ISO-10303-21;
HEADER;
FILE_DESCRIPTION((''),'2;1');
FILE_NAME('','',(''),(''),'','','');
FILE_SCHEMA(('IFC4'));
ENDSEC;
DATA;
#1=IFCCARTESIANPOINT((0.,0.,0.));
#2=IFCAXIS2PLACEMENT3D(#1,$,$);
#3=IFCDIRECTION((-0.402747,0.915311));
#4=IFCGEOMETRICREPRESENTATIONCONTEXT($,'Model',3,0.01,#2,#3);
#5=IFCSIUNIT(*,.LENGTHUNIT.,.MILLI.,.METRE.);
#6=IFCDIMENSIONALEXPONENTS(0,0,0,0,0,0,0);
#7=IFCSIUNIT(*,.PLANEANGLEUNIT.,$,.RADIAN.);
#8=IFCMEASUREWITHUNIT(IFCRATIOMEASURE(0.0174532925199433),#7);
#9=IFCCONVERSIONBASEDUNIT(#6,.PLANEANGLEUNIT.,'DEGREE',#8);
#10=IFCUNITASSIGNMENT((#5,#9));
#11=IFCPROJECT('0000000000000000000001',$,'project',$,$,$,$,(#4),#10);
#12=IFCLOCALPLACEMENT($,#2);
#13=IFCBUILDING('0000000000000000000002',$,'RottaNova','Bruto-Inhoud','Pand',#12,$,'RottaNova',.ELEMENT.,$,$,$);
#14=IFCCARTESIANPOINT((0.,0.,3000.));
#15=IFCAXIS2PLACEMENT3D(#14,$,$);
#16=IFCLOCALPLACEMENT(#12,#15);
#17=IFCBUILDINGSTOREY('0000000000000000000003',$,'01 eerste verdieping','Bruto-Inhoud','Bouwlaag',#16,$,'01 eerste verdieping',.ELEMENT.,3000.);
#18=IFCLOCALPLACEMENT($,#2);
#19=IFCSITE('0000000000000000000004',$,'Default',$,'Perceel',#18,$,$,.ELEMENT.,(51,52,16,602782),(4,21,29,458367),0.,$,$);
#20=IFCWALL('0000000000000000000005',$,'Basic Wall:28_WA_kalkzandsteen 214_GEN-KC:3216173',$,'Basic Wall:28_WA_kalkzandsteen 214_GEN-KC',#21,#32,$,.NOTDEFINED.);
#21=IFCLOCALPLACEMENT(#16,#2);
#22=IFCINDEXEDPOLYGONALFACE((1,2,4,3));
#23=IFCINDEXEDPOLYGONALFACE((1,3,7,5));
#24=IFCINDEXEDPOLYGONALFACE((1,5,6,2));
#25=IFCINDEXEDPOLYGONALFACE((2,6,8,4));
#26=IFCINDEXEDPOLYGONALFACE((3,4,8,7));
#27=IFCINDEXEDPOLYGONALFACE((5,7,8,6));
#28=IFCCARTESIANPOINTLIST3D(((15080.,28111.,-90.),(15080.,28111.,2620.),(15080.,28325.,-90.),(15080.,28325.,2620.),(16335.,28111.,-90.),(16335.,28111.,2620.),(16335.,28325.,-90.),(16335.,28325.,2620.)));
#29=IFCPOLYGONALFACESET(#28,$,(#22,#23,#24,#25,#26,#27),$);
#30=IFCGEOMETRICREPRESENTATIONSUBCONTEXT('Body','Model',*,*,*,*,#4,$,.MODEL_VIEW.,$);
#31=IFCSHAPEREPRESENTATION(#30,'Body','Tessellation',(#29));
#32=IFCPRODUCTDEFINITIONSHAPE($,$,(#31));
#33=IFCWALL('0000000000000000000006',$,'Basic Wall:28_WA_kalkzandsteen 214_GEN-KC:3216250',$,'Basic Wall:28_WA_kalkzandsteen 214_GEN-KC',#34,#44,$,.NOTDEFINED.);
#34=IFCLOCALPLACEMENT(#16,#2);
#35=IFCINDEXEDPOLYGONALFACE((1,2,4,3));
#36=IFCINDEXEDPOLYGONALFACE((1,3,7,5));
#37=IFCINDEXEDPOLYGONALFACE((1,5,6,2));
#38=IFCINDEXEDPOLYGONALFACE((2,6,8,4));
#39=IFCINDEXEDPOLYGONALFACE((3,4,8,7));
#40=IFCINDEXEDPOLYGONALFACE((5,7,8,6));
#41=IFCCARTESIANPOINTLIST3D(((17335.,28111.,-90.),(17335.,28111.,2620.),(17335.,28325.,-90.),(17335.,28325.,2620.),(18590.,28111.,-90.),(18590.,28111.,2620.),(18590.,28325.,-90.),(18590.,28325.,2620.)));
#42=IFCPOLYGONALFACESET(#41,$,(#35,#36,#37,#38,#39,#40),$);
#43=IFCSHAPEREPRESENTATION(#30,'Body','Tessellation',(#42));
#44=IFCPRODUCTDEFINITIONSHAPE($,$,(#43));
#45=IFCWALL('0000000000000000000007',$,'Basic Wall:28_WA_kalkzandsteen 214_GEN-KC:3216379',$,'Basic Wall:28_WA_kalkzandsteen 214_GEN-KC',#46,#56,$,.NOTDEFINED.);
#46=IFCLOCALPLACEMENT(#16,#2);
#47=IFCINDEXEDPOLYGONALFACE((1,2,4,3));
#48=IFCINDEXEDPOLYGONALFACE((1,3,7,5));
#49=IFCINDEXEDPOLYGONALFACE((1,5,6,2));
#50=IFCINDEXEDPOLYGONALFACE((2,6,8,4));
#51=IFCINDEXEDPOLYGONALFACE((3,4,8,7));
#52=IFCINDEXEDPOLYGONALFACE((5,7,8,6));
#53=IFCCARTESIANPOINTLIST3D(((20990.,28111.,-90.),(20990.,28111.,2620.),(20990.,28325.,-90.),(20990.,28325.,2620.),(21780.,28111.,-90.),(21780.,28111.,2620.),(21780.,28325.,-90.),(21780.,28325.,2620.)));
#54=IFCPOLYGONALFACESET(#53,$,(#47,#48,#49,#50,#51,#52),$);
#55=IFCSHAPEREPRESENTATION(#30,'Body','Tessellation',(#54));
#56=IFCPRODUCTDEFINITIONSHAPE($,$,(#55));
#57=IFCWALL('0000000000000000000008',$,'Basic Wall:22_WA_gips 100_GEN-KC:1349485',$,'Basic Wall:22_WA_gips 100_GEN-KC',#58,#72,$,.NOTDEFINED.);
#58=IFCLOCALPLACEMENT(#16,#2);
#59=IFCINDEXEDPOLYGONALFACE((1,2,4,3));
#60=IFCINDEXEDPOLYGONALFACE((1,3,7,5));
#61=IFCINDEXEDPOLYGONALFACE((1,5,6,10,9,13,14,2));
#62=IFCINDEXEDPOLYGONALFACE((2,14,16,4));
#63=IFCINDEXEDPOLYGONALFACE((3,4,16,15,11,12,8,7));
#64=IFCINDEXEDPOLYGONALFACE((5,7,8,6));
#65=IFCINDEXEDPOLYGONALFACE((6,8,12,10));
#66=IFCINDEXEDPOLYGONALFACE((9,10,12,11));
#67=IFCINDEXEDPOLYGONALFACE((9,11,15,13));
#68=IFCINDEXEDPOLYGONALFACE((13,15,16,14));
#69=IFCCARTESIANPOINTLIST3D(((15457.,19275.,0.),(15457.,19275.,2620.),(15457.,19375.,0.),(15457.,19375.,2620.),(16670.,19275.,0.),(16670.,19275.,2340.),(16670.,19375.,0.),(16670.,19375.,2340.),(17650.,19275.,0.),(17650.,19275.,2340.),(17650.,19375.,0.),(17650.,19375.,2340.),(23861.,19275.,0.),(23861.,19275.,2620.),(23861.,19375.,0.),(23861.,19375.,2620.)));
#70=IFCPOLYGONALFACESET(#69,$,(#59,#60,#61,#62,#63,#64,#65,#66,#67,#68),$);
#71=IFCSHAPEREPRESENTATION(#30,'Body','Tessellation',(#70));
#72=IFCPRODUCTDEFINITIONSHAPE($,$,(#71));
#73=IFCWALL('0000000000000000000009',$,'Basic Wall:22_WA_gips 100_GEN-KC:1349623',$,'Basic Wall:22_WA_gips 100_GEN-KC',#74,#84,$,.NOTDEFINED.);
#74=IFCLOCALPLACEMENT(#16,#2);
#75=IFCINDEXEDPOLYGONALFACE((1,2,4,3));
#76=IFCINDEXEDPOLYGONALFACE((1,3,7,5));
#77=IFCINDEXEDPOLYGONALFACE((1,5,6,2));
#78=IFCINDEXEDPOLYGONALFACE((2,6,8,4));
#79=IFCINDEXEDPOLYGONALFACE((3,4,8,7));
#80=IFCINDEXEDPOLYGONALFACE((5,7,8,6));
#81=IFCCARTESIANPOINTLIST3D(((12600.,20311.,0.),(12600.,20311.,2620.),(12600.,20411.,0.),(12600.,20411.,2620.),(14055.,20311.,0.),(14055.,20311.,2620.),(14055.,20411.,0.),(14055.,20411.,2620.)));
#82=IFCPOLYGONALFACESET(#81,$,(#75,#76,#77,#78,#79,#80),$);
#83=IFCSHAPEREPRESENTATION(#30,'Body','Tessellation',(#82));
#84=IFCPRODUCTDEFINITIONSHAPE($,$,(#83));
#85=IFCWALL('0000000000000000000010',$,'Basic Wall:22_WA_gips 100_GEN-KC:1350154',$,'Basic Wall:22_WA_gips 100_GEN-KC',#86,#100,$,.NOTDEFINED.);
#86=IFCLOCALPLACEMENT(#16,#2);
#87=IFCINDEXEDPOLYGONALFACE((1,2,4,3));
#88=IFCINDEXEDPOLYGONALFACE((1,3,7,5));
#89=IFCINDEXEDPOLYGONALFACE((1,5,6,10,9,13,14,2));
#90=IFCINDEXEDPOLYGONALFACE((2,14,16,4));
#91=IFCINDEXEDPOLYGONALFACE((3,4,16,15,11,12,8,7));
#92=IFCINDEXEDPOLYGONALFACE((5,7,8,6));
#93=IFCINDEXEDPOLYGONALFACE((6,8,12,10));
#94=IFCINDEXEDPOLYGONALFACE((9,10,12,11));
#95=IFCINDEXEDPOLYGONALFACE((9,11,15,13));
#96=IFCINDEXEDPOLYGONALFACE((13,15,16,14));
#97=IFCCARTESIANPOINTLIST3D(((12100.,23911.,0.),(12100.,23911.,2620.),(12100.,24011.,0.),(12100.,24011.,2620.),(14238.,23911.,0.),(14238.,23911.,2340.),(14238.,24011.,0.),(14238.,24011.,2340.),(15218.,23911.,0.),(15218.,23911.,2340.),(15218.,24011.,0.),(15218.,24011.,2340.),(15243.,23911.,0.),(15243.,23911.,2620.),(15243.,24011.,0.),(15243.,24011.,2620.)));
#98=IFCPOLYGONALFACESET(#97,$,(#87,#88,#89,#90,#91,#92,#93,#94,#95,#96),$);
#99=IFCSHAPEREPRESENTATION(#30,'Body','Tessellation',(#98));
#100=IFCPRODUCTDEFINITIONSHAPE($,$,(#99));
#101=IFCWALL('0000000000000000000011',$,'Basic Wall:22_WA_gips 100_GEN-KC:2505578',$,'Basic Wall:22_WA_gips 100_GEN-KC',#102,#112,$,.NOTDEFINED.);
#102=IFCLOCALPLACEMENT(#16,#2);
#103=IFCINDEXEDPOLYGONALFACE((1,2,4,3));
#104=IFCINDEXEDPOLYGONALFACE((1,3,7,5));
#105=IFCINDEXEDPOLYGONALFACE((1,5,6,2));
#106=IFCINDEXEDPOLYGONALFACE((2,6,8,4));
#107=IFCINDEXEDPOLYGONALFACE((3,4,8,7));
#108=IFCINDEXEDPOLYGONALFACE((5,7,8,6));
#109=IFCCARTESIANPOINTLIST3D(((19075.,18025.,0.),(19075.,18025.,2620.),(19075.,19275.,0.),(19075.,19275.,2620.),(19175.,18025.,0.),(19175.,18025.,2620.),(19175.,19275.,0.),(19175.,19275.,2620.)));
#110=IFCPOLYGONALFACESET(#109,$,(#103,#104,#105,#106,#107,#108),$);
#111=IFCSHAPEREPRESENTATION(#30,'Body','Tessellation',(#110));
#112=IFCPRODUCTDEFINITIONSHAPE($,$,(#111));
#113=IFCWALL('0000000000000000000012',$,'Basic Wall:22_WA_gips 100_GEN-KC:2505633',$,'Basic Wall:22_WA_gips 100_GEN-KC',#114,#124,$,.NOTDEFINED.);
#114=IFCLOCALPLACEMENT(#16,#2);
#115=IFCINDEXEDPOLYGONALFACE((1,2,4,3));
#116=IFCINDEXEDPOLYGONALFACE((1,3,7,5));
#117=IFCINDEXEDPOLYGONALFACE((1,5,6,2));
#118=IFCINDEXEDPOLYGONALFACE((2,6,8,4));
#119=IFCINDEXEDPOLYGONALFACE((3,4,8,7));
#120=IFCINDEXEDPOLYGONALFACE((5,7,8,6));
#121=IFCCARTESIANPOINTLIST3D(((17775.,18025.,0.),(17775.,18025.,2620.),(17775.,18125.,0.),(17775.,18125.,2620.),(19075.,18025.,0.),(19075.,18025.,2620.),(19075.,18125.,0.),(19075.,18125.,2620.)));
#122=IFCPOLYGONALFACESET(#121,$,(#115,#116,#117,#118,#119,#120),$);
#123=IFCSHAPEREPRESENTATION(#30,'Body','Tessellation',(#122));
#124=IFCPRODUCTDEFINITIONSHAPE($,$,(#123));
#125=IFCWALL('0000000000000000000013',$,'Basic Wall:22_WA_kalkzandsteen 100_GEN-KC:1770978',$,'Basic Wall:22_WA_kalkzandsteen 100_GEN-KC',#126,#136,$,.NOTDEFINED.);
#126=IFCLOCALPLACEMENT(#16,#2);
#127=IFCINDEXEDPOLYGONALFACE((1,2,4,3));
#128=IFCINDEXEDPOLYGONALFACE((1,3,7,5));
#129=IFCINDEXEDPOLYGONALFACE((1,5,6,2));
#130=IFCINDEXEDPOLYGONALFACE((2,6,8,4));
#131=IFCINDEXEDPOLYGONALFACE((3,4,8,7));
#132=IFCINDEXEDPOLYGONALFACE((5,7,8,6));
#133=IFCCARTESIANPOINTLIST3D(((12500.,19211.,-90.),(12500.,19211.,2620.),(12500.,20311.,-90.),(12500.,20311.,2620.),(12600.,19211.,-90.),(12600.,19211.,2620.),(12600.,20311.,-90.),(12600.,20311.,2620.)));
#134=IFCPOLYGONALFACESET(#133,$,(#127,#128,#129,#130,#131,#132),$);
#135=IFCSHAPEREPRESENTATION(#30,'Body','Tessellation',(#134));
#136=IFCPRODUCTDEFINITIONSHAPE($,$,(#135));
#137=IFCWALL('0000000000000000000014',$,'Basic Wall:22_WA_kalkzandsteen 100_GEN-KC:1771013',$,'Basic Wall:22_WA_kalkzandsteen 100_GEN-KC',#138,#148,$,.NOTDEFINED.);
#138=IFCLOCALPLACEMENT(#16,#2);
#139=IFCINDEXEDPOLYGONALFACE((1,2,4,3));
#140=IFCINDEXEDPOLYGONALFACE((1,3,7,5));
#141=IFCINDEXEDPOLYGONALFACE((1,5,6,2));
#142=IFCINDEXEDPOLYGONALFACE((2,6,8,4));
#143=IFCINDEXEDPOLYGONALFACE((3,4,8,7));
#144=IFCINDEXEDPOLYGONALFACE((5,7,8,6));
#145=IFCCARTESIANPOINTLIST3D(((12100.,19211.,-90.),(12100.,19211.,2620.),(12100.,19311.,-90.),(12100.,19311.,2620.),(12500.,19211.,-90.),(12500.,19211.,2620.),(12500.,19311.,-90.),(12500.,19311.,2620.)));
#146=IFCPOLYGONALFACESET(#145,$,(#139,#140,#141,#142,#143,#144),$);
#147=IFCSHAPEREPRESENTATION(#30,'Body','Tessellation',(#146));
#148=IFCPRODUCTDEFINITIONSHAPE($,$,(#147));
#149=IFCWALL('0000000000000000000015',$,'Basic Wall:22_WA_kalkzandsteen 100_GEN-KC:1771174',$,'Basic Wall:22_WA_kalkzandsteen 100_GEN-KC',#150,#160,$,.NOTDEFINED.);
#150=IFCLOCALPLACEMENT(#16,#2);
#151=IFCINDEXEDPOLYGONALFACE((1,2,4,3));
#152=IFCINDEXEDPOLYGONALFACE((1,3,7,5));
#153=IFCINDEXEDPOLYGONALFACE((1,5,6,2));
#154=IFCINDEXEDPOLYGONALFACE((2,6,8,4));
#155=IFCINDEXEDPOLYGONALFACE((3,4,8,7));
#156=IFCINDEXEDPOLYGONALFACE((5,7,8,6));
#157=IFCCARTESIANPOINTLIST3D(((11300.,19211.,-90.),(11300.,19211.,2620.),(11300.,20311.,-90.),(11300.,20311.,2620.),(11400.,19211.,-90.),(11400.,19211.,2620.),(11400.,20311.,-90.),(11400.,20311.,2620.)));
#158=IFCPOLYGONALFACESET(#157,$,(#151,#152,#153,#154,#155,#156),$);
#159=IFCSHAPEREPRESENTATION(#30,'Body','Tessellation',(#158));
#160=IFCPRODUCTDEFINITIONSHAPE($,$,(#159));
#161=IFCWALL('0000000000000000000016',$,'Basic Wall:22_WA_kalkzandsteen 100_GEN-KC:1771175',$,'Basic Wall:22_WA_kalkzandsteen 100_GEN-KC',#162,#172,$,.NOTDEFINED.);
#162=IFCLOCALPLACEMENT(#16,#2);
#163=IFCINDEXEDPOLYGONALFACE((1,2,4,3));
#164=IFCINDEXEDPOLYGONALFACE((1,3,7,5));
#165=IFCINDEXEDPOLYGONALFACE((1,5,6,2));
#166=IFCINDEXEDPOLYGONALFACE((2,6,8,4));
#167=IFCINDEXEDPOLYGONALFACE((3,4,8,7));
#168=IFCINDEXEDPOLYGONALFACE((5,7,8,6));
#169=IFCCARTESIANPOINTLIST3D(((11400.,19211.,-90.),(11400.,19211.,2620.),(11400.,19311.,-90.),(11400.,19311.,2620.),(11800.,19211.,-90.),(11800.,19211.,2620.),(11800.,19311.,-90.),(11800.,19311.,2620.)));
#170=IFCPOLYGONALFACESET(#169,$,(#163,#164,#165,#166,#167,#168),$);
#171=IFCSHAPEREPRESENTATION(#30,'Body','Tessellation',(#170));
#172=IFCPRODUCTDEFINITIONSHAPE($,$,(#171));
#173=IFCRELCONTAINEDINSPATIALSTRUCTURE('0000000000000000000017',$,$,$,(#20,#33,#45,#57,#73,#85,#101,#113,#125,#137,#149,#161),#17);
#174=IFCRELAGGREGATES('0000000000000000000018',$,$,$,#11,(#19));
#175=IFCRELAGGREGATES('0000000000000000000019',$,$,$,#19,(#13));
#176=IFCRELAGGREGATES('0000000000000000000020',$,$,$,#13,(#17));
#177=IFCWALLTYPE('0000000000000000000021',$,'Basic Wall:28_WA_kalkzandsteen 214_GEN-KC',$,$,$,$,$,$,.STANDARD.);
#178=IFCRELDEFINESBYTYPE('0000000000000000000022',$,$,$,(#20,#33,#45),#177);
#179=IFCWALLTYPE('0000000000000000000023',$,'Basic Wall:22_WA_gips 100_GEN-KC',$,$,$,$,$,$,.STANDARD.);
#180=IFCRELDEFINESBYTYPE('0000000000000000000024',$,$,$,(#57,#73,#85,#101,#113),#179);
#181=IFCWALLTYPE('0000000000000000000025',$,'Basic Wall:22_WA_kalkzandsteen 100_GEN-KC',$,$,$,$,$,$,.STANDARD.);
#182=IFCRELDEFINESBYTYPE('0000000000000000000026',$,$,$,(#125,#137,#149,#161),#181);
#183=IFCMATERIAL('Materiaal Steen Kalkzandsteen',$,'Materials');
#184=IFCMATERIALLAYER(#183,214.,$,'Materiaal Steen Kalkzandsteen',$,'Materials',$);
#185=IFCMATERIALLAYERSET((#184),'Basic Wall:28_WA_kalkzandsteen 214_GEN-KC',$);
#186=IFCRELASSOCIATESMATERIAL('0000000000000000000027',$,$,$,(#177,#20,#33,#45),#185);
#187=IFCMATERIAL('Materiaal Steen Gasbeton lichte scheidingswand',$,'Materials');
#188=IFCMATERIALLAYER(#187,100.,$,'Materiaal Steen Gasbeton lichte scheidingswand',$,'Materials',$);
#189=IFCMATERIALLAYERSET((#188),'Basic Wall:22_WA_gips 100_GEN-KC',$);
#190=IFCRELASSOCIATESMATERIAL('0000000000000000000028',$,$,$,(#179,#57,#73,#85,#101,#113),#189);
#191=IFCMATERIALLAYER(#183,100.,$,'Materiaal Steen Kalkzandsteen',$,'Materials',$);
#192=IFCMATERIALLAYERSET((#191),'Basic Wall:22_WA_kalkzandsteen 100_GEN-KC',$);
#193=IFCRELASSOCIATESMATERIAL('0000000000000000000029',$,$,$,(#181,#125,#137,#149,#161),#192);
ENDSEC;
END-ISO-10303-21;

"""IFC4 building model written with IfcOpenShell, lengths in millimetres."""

from ifc_helpers import new_model, entity, si_unit, converted_unit, direction, frame, frame_2d, origin, place, context, subcontext, project, spatial, rectangle, extrude, material, layer, layer_set, type_object, element, save


model = new_model("IFC4")

# Units and contexts
model_context = context("Model", 3, precision=0.01, world=origin(), true_north=direction((-0.402747, 0.915311)))
body_context = subcontext(model_context, "Body", "Model", "MODEL_VIEW")
ifc_project = project(units=[si_unit("LENGTHUNIT", "METRE", prefix="MILLI"), converted_unit("PLANEANGLEUNIT", "DEGREE", entity("IfcRatioMeasure", 0.0174532925199433), si_unit("PLANEANGLEUNIT", "RADIAN"), dimensions=[0, 0, 0, 0, 0, 0, 0])], contexts=[model_context])

# Site, building, storey
site_placement = place(None, origin())
site = spatial("IfcSite", under=ifc_project, at=site_placement, Name="Default", ObjectType="Perceel", CompositionType="ELEMENT", RefLatitude=(51, 52, 16, 602782), RefLongitude=(4, 21, 29, 458367), RefElevation=0.0)
building_placement = place(None, origin())
building = spatial("IfcBuilding", under=site, at=building_placement, Name="RottaNova", Description="Bruto-Inhoud", ObjectType="Pand", LongName="RottaNova", CompositionType="ELEMENT")
storey_placement = place(building_placement, frame((0.0, 0.0, 3000.0)))
storey = spatial("IfcBuildingStorey", under=building, at=storey_placement, Name="01 eerste verdieping", Description="Bruto-Inhoud", ObjectType="Bouwlaag", LongName="01 eerste verdieping", CompositionType="ELEMENT", Elevation=3000.0)

# Walls
ifc_material_1 = material(Name="Materiaal Steen Kalkzandsteen", Category="Materials")
ifc_layer_1 = layer(ifc_material_1, 214.0, Name="Materiaal Steen Kalkzandsteen", Category="Materials")
ifc_layer_set_1 = layer_set([ifc_layer_1], Name="Basic Wall:28_WA_kalkzandsteen 214_GEN-KC")
wall_type_1 = type_object("IfcWallType", Name="Basic Wall:28_WA_kalkzandsteen 214_GEN-KC", PredefinedType="STANDARD", material=ifc_layer_set_1)
wall_1_placement = place(storey_placement, frame((15080.0, 28218.0, -90.0)))
element("IfcWall", 1, at=wall_1_placement, inside=storey, type_object=wall_type_1, material=ifc_layer_set_1, Name="Basic Wall:28_WA_kalkzandsteen 214_GEN-KC:3216173", ObjectType="Basic Wall:28_WA_kalkzandsteen 214_GEN-KC", PredefinedType="NOTDEFINED", context=body_context, shape_type="SweptSolid", body=[
    extrude(rectangle(XDim=1255.0, YDim=214.0, at=frame_2d((627.5, 0.0), x_axis=(-1.0, 0.0))), origin(), (0.0, 0.0, 1.0), 2710.0),
])
wall_2_placement = place(storey_placement, frame((17335.0, 28218.0, -90.0)))
element("IfcWall", 2, at=wall_2_placement, inside=storey, type_object=wall_type_1, material=ifc_layer_set_1, Name="Basic Wall:28_WA_kalkzandsteen 214_GEN-KC:3216250", ObjectType="Basic Wall:28_WA_kalkzandsteen 214_GEN-KC", PredefinedType="NOTDEFINED", context=body_context, shape_type="SweptSolid", body=[
    extrude(rectangle(XDim=1255.0, YDim=214.0, at=frame_2d((627.5, 0.0), x_axis=(-1.0, 0.0))), origin(), (0.0, 0.0, 1.0), 2710.0),
])
wall_3_placement = place(storey_placement, frame((20990.0, 28218.0, -90.0)))
element("IfcWall", 3, at=wall_3_placement, inside=storey, type_object=wall_type_1, material=ifc_layer_set_1, Name="Basic Wall:28_WA_kalkzandsteen 214_GEN-KC:3216379", ObjectType="Basic Wall:28_WA_kalkzandsteen 214_GEN-KC", PredefinedType="NOTDEFINED", context=body_context, shape_type="SweptSolid", body=[
    extrude(rectangle(XDim=790.0, YDim=214.0, at=frame_2d((395.0, 0.0), x_axis=(-1.0, 0.0))), origin(), (0.0, 0.0, 1.0), 2710.0),
])

# Wall, opening
ifc_material_2 = material(Name="Materiaal Steen Gasbeton lichte scheidingswand", Category="Materials")
ifc_layer_2 = layer(ifc_material_2, 100.0, Name="Materiaal Steen Gasbeton lichte scheidingswand", Category="Materials")
ifc_layer_set_2 = layer_set([ifc_layer_2], Name="Basic Wall:22_WA_gips 100_GEN-KC")
wall_type_2 = type_object("IfcWallType", Name="Basic Wall:22_WA_gips 100_GEN-KC", PredefinedType="STANDARD", material=ifc_layer_set_2)
wall_4_placement = place(storey_placement, frame((23861.0, 19325.0, 0.0), z_axis=(0.0, 0.0, 1.0), x_axis=(-1.0, 0.0, 0.0)))
wall_4 = element("IfcWall", 4, at=wall_4_placement, inside=storey, type_object=wall_type_2, material=ifc_layer_set_2, Name="Basic Wall:22_WA_gips 100_GEN-KC:1349485", ObjectType="Basic Wall:22_WA_gips 100_GEN-KC", PredefinedType="NOTDEFINED", context=body_context, shape_type="SweptSolid", body=[
    extrude(rectangle(XDim=8404.0, YDim=100.0, at=frame_2d((4202.0, 0.0), x_axis=(-1.0, 0.0))), origin(), (0.0, 0.0, 1.0), 2620.0),
])
opening_1_placement = place(wall_4_placement, frame((7191.0, 50.0, -90.0)))
element("IfcOpeningElement", 5, at=opening_1_placement, cuts=wall_4, PredefinedType="OPENING", context=body_context, shape_type="SweptSolid", body=[
    extrude(rectangle(XDim=2430.0, YDim=980.0, at=frame_2d((1215.0, 490.0), x_axis=(1.0, 0.0))), frame((0.0, 0.0, 0.0), z_axis=(0.0, -1.0, 0.0), x_axis=(0.0, 0.0, 1.0)), (0.0, 0.0, 1.0), 100.0),
])

# Wall
wall_5_placement = place(storey_placement, frame((14055.0, 20361.0, 0.0), z_axis=(0.0, 0.0, 1.0), x_axis=(-1.0, 0.0, 0.0)))
element("IfcWall", 6, at=wall_5_placement, inside=storey, type_object=wall_type_2, material=ifc_layer_set_2, Name="Basic Wall:22_WA_gips 100_GEN-KC:1349623", ObjectType="Basic Wall:22_WA_gips 100_GEN-KC", PredefinedType="NOTDEFINED", context=body_context, shape_type="SweptSolid", body=[
    extrude(rectangle(XDim=1455.0, YDim=100.0, at=frame_2d((727.5, 0.0), x_axis=(-1.0, 0.0))), origin(), (0.0, 0.0, 1.0), 2620.0),
])

# Wall, opening
wall_6_placement = place(storey_placement, frame((15243.0, 23961.0, 0.0), z_axis=(0.0, 0.0, 1.0), x_axis=(-1.0, 0.0, 0.0)))
wall_6 = element("IfcWall", 7, at=wall_6_placement, inside=storey, type_object=wall_type_2, material=ifc_layer_set_2, Name="Basic Wall:22_WA_gips 100_GEN-KC:1350154", ObjectType="Basic Wall:22_WA_gips 100_GEN-KC", PredefinedType="NOTDEFINED", context=body_context, shape_type="SweptSolid", body=[
    extrude(rectangle(XDim=3143.0, YDim=100.0, at=frame_2d((1571.5, 0.0), x_axis=(-1.0, 0.0))), origin(), (0.0, 0.0, 1.0), 2620.0),
])
opening_2_placement = place(wall_6_placement, frame((1005.0, 50.0, -90.0)))
element("IfcOpeningElement", 8, at=opening_2_placement, cuts=wall_6, PredefinedType="OPENING", context=body_context, shape_type="SweptSolid", body=[
    extrude(rectangle(XDim=2430.0, YDim=980.0, at=frame_2d((1215.0, 490.0), x_axis=(1.0, 0.0))), frame((0.0, 0.0, 0.0), z_axis=(0.0, -1.0, 0.0), x_axis=(0.0, 0.0, 1.0)), (0.0, 0.0, 1.0), 100.0),
])

# Walls
wall_7_placement = place(storey_placement, frame((19125.0, 19275.0, 0.0), z_axis=(0.0, 0.0, 1.0), x_axis=(0.0, -1.0, 0.0)))
element("IfcWall", 9, at=wall_7_placement, inside=storey, type_object=wall_type_2, material=ifc_layer_set_2, Name="Basic Wall:22_WA_gips 100_GEN-KC:2505578", ObjectType="Basic Wall:22_WA_gips 100_GEN-KC", PredefinedType="NOTDEFINED", context=body_context, shape_type="SweptSolid", body=[
    extrude(rectangle(XDim=1250.0, YDim=100.0, at=frame_2d((625.0, 0.0), x_axis=(-1.0, 0.0))), origin(), (0.0, 0.0, 1.0), 2620.0),
])
wall_8_placement = place(storey_placement, frame((19075.0, 18075.0, 0.0), z_axis=(0.0, 0.0, 1.0), x_axis=(-1.0, 0.0, 0.0)))
element("IfcWall", 10, at=wall_8_placement, inside=storey, type_object=wall_type_2, material=ifc_layer_set_2, Name="Basic Wall:22_WA_gips 100_GEN-KC:2505633", ObjectType="Basic Wall:22_WA_gips 100_GEN-KC", PredefinedType="NOTDEFINED", context=body_context, shape_type="SweptSolid", body=[
    extrude(rectangle(XDim=1300.0, YDim=100.0, at=frame_2d((650.0, 0.0), x_axis=(-1.0, 0.0))), origin(), (0.0, 0.0, 1.0), 2620.0),
])
ifc_layer_3 = layer(ifc_material_1, 100.0, Name="Materiaal Steen Kalkzandsteen", Category="Materials")
ifc_layer_set_3 = layer_set([ifc_layer_3], Name="Basic Wall:22_WA_kalkzandsteen 100_GEN-KC")
wall_type_3 = type_object("IfcWallType", Name="Basic Wall:22_WA_kalkzandsteen 100_GEN-KC", PredefinedType="STANDARD", material=ifc_layer_set_3)
wall_9_placement = place(storey_placement, frame((12550.0, 20311.0, -90.0), z_axis=(0.0, 0.0, 1.0), x_axis=(0.0, -1.0, 0.0)))
element("IfcWall", 11, at=wall_9_placement, inside=storey, type_object=wall_type_3, material=ifc_layer_set_3, Name="Basic Wall:22_WA_kalkzandsteen 100_GEN-KC:1770978", ObjectType="Basic Wall:22_WA_kalkzandsteen 100_GEN-KC", PredefinedType="NOTDEFINED", context=body_context, shape_type="SweptSolid", body=[
    extrude(rectangle(XDim=1100.0, YDim=100.0, at=frame_2d((550.0, 0.0), x_axis=(-1.0, 0.0))), origin(), (0.0, 0.0, 1.0), 2710.0),
])
wall_10_placement = place(storey_placement, frame((12500.0, 19261.0, -90.0), z_axis=(0.0, 0.0, 1.0), x_axis=(-1.0, 0.0, 0.0)))
element("IfcWall", 12, at=wall_10_placement, inside=storey, type_object=wall_type_3, material=ifc_layer_set_3, Name="Basic Wall:22_WA_kalkzandsteen 100_GEN-KC:1771013", ObjectType="Basic Wall:22_WA_kalkzandsteen 100_GEN-KC", PredefinedType="NOTDEFINED", context=body_context, shape_type="SweptSolid", body=[
    extrude(rectangle(XDim=400.0, YDim=100.0, at=frame_2d((200.0, 0.0), x_axis=(-1.0, 0.0))), origin(), (0.0, 0.0, 1.0), 2710.0),
])
wall_11_placement = place(storey_placement, frame((11350.0, 20311.0, -90.0), z_axis=(0.0, 0.0, 1.0), x_axis=(0.0, -1.0, 0.0)))
element("IfcWall", 13, at=wall_11_placement, inside=storey, type_object=wall_type_3, material=ifc_layer_set_3, Name="Basic Wall:22_WA_kalkzandsteen 100_GEN-KC:1771174", ObjectType="Basic Wall:22_WA_kalkzandsteen 100_GEN-KC", PredefinedType="NOTDEFINED", context=body_context, shape_type="SweptSolid", body=[
    extrude(rectangle(XDim=1100.0, YDim=100.0, at=frame_2d((550.0, 0.0), x_axis=(-1.0, 0.0))), origin(), (0.0, 0.0, 1.0), 2710.0),
])
wall_12_placement = place(storey_placement, frame((11400.0, 19261.0, -90.0)))
element("IfcWall", 14, at=wall_12_placement, inside=storey, type_object=wall_type_3, material=ifc_layer_set_3, Name="Basic Wall:22_WA_kalkzandsteen 100_GEN-KC:1771175", ObjectType="Basic Wall:22_WA_kalkzandsteen 100_GEN-KC", PredefinedType="NOTDEFINED", context=body_context, shape_type="SweptSolid", body=[
    extrude(rectangle(XDim=400.0, YDim=100.0, at=frame_2d((200.0, 0.0), x_axis=(-1.0, 0.0))), origin(), (0.0, 0.0, 1.0), 2710.0),
])

save(model, "model.ifc")
